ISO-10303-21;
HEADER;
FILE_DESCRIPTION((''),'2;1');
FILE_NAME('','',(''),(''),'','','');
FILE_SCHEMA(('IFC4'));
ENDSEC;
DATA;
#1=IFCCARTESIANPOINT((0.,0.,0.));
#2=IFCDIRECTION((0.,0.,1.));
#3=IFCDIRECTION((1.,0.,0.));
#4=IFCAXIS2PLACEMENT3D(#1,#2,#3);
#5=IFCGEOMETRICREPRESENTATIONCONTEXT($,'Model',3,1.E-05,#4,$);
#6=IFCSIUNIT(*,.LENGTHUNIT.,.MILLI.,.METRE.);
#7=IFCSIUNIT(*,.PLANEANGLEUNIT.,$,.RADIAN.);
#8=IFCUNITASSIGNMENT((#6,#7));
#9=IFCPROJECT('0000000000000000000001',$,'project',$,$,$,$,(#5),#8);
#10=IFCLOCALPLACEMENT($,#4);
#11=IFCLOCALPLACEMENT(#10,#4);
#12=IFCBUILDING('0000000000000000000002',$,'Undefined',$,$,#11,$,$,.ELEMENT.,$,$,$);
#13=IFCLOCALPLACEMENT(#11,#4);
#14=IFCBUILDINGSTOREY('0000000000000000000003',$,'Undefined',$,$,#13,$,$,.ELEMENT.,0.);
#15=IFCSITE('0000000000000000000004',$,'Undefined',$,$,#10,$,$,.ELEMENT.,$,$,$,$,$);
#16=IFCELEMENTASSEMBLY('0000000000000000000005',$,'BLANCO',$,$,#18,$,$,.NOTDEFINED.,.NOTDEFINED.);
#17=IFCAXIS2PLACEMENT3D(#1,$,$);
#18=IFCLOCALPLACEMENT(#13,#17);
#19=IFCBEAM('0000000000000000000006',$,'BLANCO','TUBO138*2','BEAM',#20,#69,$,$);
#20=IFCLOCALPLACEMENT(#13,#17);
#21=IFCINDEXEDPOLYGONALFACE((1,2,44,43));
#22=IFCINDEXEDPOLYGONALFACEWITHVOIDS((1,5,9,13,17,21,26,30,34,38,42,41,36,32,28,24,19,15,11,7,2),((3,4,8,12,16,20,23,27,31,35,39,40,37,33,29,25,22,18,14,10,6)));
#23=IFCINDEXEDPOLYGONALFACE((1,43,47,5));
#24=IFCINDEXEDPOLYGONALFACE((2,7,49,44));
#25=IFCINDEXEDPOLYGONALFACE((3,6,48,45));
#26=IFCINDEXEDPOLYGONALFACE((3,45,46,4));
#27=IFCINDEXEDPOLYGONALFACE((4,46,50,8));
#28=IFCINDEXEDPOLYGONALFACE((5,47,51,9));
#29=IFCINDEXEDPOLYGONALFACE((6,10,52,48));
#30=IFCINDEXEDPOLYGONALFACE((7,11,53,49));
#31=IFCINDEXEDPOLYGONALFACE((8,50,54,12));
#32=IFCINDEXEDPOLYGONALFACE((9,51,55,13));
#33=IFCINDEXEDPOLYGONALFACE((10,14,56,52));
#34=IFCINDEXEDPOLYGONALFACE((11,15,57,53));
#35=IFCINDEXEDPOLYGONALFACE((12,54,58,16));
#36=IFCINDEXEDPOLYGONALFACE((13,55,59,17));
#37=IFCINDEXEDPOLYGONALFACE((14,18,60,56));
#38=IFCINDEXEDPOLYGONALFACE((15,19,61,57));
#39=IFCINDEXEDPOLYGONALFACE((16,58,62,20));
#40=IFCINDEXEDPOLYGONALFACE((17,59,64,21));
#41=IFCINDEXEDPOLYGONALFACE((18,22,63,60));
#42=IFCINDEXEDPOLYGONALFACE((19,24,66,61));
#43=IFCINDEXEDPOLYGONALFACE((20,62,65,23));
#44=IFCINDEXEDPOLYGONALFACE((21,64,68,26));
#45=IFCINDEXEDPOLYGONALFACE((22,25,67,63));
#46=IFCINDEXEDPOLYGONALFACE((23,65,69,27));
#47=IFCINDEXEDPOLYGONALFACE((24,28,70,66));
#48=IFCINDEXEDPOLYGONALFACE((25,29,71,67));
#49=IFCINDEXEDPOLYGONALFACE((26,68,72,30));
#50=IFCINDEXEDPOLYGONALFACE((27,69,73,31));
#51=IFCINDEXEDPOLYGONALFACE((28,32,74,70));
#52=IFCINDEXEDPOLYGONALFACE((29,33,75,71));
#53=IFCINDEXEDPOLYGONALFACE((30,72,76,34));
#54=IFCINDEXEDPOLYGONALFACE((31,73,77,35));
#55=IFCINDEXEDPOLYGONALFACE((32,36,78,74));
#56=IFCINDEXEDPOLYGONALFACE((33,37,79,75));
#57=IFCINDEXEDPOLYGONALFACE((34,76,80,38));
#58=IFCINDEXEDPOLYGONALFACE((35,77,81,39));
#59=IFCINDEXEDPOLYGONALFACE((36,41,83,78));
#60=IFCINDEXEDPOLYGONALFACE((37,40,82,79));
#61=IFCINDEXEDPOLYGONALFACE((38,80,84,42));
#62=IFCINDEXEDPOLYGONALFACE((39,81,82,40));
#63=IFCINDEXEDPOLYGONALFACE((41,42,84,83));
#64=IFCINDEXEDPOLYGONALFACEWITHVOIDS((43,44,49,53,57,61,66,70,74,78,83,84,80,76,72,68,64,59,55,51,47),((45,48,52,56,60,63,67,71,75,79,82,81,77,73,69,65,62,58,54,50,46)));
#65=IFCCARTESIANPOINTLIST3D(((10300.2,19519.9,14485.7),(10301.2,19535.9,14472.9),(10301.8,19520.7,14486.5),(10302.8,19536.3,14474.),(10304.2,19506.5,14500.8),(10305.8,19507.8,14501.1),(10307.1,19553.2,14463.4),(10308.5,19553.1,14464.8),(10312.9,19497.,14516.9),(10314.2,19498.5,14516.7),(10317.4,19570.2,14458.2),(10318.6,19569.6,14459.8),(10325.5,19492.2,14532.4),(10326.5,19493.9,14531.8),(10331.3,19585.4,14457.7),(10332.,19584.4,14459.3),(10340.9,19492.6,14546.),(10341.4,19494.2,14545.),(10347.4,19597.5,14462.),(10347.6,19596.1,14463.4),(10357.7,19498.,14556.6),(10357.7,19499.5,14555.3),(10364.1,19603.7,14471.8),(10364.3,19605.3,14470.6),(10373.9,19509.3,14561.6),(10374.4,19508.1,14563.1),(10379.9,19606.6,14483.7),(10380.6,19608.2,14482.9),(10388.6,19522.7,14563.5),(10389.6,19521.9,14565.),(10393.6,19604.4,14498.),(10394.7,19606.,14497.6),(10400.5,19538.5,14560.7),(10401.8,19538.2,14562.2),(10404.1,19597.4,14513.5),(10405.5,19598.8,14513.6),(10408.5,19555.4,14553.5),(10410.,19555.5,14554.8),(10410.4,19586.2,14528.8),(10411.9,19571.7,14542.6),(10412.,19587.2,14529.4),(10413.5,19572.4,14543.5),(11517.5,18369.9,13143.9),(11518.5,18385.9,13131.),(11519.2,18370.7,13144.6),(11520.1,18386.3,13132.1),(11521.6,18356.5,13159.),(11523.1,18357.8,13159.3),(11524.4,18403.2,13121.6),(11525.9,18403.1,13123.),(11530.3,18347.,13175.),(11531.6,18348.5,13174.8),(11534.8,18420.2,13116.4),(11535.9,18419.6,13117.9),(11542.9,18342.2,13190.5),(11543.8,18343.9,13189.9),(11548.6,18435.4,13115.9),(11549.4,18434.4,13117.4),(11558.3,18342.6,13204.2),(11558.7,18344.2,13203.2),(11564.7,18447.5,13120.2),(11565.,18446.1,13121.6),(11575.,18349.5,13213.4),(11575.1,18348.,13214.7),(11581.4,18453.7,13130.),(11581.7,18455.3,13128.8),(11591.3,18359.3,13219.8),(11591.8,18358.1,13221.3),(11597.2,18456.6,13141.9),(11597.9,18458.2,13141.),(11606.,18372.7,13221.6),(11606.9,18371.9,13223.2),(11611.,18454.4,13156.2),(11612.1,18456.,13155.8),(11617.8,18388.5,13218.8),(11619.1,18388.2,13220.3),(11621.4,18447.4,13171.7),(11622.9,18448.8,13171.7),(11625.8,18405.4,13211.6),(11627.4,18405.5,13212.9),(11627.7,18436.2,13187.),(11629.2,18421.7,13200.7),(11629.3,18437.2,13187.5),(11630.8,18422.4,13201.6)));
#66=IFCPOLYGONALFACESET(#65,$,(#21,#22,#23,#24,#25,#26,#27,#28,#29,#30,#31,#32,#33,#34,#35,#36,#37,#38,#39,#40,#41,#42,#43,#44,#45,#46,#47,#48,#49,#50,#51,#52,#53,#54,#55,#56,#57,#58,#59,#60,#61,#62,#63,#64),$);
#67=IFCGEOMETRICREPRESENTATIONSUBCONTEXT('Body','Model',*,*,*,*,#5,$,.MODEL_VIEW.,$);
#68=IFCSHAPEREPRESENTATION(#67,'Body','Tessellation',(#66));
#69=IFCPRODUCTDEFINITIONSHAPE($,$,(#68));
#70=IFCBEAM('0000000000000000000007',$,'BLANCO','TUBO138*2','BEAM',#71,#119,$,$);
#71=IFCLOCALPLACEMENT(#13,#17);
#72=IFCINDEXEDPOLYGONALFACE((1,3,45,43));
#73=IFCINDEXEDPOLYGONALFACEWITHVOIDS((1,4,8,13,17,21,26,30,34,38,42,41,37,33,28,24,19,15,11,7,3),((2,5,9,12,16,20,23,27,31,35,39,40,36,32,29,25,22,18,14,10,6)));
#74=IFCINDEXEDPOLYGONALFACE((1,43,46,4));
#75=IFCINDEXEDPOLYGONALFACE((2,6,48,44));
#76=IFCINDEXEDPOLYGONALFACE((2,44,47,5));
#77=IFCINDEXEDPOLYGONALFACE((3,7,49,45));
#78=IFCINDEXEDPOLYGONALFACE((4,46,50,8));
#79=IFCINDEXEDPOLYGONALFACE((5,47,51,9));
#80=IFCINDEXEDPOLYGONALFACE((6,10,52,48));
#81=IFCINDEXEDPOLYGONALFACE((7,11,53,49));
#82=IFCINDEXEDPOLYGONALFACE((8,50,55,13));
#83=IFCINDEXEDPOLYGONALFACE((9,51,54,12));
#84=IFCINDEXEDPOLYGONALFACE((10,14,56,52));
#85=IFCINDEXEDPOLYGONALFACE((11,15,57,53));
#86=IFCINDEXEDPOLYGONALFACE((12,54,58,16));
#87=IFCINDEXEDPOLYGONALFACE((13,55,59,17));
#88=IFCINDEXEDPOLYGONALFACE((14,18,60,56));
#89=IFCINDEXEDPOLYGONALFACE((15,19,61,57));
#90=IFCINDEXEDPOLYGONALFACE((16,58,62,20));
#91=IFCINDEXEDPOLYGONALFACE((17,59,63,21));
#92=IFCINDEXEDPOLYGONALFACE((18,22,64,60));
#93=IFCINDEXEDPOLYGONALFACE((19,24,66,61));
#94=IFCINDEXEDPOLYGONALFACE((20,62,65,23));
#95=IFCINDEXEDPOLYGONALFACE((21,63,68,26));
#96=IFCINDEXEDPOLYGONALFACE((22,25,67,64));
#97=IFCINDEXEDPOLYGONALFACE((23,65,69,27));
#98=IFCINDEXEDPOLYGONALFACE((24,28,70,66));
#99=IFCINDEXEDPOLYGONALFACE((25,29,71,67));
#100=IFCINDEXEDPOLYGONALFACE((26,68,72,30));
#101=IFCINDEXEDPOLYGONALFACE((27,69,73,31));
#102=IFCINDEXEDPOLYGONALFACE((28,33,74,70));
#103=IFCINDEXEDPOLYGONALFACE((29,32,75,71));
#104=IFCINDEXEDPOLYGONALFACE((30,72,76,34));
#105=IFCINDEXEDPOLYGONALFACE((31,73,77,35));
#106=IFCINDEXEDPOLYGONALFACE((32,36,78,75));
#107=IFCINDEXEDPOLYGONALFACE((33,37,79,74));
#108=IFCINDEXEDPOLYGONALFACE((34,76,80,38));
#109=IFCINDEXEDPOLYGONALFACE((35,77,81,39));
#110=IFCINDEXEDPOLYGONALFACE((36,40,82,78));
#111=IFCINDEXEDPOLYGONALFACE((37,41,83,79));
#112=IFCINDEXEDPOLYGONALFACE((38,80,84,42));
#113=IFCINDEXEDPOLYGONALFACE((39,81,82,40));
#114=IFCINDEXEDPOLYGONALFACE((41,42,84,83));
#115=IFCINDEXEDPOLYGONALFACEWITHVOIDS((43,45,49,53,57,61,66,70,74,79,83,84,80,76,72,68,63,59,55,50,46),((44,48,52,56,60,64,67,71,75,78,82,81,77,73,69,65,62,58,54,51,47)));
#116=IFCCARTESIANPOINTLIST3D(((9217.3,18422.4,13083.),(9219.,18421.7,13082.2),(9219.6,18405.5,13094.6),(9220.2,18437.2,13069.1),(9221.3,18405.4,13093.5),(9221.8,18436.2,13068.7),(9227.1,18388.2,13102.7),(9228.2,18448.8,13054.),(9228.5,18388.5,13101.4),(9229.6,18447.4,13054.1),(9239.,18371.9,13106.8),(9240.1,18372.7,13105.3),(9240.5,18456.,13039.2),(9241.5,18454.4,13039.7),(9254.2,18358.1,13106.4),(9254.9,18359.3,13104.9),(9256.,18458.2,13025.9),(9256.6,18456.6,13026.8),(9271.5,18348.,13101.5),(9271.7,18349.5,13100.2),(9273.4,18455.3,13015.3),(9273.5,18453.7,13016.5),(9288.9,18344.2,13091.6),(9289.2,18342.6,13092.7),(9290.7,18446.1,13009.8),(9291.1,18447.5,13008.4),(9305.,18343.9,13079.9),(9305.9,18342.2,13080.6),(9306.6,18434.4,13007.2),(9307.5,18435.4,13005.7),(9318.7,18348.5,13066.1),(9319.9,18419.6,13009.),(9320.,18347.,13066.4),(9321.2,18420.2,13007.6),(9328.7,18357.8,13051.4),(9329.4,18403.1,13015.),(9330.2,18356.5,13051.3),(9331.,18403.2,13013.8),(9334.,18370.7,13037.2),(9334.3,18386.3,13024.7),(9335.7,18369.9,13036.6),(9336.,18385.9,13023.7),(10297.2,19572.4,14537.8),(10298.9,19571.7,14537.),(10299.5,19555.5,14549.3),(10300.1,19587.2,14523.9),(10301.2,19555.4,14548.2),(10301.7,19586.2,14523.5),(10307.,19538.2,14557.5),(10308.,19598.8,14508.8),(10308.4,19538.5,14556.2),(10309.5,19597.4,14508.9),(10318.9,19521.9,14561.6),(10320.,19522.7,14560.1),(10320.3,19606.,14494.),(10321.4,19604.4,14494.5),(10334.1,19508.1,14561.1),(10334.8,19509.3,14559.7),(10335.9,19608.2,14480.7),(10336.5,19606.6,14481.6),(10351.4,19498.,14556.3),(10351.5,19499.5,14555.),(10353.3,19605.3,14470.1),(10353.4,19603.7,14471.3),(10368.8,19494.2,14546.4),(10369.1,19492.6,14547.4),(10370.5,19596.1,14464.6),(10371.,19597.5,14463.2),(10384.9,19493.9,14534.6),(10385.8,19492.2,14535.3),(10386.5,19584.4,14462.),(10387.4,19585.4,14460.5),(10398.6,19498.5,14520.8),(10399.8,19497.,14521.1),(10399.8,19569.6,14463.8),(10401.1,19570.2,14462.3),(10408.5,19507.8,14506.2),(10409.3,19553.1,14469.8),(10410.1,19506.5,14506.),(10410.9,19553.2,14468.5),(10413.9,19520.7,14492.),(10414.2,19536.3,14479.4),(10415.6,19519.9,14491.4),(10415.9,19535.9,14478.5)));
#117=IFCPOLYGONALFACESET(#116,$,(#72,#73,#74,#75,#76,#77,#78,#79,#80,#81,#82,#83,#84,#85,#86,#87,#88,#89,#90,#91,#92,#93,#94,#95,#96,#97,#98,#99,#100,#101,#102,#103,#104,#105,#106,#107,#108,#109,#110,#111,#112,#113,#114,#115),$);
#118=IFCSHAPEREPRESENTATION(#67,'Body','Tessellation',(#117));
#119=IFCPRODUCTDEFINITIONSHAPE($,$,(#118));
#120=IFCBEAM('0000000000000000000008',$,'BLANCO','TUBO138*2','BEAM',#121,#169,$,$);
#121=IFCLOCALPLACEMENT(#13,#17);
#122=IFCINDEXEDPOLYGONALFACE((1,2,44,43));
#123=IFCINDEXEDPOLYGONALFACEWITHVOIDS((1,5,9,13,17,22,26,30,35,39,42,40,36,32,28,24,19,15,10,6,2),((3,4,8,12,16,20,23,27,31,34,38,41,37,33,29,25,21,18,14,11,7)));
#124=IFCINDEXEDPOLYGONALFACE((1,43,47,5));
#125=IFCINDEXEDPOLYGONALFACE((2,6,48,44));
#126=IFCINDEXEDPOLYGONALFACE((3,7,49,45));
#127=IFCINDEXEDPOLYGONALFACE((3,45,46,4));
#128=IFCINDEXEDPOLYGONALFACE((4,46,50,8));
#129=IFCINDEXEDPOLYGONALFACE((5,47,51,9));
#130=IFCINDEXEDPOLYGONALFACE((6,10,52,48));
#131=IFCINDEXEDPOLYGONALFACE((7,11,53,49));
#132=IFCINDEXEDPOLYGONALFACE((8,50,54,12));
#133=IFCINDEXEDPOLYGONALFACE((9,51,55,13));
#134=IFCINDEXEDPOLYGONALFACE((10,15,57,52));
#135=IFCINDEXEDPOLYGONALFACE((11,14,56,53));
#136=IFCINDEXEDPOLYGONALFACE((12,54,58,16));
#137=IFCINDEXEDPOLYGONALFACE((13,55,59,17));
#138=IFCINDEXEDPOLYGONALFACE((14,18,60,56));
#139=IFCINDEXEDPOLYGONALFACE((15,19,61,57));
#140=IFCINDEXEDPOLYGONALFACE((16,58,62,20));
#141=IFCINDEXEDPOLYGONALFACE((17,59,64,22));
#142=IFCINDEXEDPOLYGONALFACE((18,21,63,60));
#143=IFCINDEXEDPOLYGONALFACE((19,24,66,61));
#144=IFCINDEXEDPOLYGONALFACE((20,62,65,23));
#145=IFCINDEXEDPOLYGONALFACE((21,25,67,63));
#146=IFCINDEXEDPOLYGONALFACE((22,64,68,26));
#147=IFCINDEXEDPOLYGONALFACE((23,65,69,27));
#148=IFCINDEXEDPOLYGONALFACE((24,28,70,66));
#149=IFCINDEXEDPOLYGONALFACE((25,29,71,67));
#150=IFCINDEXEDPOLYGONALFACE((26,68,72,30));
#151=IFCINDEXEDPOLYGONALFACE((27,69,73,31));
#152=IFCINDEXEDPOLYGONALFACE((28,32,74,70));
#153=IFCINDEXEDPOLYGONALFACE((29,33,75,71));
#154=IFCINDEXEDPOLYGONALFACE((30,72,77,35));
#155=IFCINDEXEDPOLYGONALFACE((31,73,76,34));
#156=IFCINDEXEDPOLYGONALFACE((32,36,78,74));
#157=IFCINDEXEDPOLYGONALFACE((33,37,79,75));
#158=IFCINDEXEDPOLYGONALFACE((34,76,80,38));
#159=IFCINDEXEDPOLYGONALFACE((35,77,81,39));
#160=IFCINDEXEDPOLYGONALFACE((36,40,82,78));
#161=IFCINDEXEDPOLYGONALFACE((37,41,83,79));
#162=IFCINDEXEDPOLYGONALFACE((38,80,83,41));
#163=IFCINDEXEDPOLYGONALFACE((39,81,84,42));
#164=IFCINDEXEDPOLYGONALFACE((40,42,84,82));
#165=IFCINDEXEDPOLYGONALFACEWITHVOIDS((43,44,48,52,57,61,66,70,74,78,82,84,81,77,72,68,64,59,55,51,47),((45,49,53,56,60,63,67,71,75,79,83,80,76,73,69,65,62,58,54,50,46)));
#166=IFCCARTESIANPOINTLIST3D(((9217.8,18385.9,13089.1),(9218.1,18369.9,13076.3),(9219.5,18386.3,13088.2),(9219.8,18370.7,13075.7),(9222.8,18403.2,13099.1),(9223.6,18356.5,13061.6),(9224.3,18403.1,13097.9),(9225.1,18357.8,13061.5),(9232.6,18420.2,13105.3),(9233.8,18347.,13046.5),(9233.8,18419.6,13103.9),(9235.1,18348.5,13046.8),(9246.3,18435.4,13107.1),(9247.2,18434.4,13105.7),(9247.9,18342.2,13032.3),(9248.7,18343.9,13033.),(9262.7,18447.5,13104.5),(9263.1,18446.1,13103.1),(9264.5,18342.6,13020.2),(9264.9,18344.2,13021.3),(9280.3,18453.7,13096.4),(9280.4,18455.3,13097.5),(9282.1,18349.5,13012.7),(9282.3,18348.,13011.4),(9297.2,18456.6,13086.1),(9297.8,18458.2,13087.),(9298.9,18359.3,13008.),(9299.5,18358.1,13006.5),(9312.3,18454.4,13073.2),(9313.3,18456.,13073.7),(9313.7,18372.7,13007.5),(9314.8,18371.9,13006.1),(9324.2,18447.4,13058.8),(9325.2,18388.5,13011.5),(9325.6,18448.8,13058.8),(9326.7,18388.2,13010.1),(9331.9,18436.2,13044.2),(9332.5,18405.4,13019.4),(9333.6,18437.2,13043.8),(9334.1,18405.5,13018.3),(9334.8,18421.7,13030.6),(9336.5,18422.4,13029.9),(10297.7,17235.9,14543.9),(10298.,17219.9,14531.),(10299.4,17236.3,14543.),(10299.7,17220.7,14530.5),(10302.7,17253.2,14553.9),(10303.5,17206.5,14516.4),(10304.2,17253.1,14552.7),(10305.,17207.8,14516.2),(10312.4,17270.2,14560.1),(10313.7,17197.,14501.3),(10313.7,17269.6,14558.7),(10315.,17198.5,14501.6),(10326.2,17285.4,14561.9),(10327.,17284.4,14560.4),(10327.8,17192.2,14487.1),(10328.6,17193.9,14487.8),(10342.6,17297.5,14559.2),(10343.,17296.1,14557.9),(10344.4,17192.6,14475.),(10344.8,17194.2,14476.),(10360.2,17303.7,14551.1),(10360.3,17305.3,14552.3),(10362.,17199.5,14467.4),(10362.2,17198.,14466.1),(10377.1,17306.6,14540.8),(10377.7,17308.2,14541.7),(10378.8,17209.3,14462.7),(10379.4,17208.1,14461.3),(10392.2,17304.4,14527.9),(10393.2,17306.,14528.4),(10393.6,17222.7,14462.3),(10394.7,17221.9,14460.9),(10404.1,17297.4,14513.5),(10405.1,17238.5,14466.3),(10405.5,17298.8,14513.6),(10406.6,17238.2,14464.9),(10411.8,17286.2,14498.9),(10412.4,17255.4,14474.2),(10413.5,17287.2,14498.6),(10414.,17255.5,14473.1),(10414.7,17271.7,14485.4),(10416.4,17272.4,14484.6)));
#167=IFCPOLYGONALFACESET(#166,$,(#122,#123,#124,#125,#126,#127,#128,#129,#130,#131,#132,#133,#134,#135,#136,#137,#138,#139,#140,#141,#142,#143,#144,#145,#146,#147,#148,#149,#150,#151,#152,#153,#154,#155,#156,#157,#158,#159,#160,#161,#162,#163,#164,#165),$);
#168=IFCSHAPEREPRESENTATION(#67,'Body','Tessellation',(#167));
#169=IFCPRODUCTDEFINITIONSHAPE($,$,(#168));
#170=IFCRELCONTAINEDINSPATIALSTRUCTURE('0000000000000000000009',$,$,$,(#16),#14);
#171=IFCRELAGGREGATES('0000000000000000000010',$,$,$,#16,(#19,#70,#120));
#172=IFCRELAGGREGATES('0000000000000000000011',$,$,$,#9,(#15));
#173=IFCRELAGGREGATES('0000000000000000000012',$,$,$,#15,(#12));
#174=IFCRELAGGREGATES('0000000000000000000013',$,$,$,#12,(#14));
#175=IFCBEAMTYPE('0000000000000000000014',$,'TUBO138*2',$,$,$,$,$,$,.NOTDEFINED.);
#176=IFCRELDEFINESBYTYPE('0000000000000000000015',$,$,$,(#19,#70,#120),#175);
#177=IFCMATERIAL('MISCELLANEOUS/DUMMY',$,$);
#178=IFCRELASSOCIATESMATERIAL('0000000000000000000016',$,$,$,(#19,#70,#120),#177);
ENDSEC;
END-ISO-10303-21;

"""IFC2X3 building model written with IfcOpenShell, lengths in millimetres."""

from ifc_helpers import new_model, si_unit, frame, origin_with_axes, origin_2d_with_axis, place, context, subcontext, project, spatial, hollow_circle, extrude, material, type_object, element, aggregate, save


model = new_model("IFC2X3")

# Units and contexts
model_context = context("Model", 3, precision=1e-05, world=origin_with_axes())
body_context = subcontext(model_context, "Body", "Model", "MODEL_VIEW")
ifc_project = project(units=[si_unit("LENGTHUNIT", "METRE", prefix="MILLI"), si_unit("PLANEANGLEUNIT", "RADIAN")], contexts=[model_context])

# Site, building, storey
site_placement = place(None, origin_with_axes())
site = spatial("IfcSite", under=ifc_project, at=site_placement, Name="Undefined", CompositionType="ELEMENT")
building_placement = place(site_placement, origin_with_axes())
building = spatial("IfcBuilding", under=site, at=building_placement, Name="Undefined", CompositionType="ELEMENT")
storey_placement = place(building_placement, origin_with_axes())
storey = spatial("IfcBuildingStorey", under=building, at=storey_placement, Name="Undefined", CompositionType="ELEMENT", Elevation=0.0)

# Element assembly, beams
assembly_placement = place(storey_placement, origin_with_axes())
assembly = element("IfcElementAssembly", 1, at=assembly_placement, inside=storey, Name="BLANCO", AssemblyPlace="NOTDEFINED", PredefinedType="NOTDEFINED")
ifc_material = material(Name="MISCELLANEOUS/DUMMY")
beam_type = type_object("IfcBeamType", Name="TUBO138*2", PredefinedType="NOTDEFINED")
beam_1_placement = place(assembly_placement, frame((10356.8, 19550.0, 14511.2), z_axis=(-0.423552, 0.461316, -0.77961), x_axis=(0.567282, -0.535899, -0.625303)))
beam_1 = element("IfcBeam", 2, at=beam_1_placement, type_object=beam_type, material=ifc_material, Name="BLANCO", Description="TUBO138*2", ObjectType="BEAM", context=body_context, shape_type="SweptSolid", body=[
    extrude(hollow_circle(Radius=69.0, WallThickness=2.0, at=origin_2d_with_axis()), frame((2145.9, 0.0, 0.0), z_axis=(-1.0, 0.0, 0.0), x_axis=(0.0, -1.0, 0.0)), (0.0, 0.0, 1.0), 2145.9),
])
beam_2_placement = place(assembly_placement, frame((9276.9, 18400.0, 13056.4), z_axis=(0.497966, 0.461316, -0.734314), x_axis=(0.503224, 0.535899, 0.677922)))
beam_2 = element("IfcBeam", 3, at=beam_2_placement, type_object=beam_type, material=ifc_material, Name="BLANCO", Description="TUBO138*2", ObjectType="BEAM", context=body_context, shape_type="SweptSolid", body=[
    extrude(hollow_circle(Radius=69.0, WallThickness=2.0, at=origin_2d_with_axis()), frame((2145.9, 0.0, 0.0), z_axis=(-1.0, 0.0, 0.0), x_axis=(0.0, -1.0, 0.0)), (0.0, 0.0, 1.0), 2145.9),
])
beam_3_placement = place(assembly_placement, frame((9276.9, 18400.0, 13056.4), z_axis=(0.497966, -0.461316, -0.734314), x_axis=(0.503224, -0.535899, 0.677922)))
beam_3 = element("IfcBeam", 4, at=beam_3_placement, type_object=beam_type, material=ifc_material, Name="BLANCO", Description="TUBO138*2", ObjectType="BEAM", context=body_context, shape_type="SweptSolid", body=[
    extrude(hollow_circle(Radius=69.0, WallThickness=2.0, at=origin_2d_with_axis()), frame((2145.9, 0.0, 0.0), z_axis=(-1.0, 0.0, 0.0), x_axis=(0.0, -1.0, 0.0)), (0.0, 0.0, 1.0), 2145.9),
])
aggregate(assembly, [beam_1, beam_2, beam_3])

save(model, "model.ifc")
